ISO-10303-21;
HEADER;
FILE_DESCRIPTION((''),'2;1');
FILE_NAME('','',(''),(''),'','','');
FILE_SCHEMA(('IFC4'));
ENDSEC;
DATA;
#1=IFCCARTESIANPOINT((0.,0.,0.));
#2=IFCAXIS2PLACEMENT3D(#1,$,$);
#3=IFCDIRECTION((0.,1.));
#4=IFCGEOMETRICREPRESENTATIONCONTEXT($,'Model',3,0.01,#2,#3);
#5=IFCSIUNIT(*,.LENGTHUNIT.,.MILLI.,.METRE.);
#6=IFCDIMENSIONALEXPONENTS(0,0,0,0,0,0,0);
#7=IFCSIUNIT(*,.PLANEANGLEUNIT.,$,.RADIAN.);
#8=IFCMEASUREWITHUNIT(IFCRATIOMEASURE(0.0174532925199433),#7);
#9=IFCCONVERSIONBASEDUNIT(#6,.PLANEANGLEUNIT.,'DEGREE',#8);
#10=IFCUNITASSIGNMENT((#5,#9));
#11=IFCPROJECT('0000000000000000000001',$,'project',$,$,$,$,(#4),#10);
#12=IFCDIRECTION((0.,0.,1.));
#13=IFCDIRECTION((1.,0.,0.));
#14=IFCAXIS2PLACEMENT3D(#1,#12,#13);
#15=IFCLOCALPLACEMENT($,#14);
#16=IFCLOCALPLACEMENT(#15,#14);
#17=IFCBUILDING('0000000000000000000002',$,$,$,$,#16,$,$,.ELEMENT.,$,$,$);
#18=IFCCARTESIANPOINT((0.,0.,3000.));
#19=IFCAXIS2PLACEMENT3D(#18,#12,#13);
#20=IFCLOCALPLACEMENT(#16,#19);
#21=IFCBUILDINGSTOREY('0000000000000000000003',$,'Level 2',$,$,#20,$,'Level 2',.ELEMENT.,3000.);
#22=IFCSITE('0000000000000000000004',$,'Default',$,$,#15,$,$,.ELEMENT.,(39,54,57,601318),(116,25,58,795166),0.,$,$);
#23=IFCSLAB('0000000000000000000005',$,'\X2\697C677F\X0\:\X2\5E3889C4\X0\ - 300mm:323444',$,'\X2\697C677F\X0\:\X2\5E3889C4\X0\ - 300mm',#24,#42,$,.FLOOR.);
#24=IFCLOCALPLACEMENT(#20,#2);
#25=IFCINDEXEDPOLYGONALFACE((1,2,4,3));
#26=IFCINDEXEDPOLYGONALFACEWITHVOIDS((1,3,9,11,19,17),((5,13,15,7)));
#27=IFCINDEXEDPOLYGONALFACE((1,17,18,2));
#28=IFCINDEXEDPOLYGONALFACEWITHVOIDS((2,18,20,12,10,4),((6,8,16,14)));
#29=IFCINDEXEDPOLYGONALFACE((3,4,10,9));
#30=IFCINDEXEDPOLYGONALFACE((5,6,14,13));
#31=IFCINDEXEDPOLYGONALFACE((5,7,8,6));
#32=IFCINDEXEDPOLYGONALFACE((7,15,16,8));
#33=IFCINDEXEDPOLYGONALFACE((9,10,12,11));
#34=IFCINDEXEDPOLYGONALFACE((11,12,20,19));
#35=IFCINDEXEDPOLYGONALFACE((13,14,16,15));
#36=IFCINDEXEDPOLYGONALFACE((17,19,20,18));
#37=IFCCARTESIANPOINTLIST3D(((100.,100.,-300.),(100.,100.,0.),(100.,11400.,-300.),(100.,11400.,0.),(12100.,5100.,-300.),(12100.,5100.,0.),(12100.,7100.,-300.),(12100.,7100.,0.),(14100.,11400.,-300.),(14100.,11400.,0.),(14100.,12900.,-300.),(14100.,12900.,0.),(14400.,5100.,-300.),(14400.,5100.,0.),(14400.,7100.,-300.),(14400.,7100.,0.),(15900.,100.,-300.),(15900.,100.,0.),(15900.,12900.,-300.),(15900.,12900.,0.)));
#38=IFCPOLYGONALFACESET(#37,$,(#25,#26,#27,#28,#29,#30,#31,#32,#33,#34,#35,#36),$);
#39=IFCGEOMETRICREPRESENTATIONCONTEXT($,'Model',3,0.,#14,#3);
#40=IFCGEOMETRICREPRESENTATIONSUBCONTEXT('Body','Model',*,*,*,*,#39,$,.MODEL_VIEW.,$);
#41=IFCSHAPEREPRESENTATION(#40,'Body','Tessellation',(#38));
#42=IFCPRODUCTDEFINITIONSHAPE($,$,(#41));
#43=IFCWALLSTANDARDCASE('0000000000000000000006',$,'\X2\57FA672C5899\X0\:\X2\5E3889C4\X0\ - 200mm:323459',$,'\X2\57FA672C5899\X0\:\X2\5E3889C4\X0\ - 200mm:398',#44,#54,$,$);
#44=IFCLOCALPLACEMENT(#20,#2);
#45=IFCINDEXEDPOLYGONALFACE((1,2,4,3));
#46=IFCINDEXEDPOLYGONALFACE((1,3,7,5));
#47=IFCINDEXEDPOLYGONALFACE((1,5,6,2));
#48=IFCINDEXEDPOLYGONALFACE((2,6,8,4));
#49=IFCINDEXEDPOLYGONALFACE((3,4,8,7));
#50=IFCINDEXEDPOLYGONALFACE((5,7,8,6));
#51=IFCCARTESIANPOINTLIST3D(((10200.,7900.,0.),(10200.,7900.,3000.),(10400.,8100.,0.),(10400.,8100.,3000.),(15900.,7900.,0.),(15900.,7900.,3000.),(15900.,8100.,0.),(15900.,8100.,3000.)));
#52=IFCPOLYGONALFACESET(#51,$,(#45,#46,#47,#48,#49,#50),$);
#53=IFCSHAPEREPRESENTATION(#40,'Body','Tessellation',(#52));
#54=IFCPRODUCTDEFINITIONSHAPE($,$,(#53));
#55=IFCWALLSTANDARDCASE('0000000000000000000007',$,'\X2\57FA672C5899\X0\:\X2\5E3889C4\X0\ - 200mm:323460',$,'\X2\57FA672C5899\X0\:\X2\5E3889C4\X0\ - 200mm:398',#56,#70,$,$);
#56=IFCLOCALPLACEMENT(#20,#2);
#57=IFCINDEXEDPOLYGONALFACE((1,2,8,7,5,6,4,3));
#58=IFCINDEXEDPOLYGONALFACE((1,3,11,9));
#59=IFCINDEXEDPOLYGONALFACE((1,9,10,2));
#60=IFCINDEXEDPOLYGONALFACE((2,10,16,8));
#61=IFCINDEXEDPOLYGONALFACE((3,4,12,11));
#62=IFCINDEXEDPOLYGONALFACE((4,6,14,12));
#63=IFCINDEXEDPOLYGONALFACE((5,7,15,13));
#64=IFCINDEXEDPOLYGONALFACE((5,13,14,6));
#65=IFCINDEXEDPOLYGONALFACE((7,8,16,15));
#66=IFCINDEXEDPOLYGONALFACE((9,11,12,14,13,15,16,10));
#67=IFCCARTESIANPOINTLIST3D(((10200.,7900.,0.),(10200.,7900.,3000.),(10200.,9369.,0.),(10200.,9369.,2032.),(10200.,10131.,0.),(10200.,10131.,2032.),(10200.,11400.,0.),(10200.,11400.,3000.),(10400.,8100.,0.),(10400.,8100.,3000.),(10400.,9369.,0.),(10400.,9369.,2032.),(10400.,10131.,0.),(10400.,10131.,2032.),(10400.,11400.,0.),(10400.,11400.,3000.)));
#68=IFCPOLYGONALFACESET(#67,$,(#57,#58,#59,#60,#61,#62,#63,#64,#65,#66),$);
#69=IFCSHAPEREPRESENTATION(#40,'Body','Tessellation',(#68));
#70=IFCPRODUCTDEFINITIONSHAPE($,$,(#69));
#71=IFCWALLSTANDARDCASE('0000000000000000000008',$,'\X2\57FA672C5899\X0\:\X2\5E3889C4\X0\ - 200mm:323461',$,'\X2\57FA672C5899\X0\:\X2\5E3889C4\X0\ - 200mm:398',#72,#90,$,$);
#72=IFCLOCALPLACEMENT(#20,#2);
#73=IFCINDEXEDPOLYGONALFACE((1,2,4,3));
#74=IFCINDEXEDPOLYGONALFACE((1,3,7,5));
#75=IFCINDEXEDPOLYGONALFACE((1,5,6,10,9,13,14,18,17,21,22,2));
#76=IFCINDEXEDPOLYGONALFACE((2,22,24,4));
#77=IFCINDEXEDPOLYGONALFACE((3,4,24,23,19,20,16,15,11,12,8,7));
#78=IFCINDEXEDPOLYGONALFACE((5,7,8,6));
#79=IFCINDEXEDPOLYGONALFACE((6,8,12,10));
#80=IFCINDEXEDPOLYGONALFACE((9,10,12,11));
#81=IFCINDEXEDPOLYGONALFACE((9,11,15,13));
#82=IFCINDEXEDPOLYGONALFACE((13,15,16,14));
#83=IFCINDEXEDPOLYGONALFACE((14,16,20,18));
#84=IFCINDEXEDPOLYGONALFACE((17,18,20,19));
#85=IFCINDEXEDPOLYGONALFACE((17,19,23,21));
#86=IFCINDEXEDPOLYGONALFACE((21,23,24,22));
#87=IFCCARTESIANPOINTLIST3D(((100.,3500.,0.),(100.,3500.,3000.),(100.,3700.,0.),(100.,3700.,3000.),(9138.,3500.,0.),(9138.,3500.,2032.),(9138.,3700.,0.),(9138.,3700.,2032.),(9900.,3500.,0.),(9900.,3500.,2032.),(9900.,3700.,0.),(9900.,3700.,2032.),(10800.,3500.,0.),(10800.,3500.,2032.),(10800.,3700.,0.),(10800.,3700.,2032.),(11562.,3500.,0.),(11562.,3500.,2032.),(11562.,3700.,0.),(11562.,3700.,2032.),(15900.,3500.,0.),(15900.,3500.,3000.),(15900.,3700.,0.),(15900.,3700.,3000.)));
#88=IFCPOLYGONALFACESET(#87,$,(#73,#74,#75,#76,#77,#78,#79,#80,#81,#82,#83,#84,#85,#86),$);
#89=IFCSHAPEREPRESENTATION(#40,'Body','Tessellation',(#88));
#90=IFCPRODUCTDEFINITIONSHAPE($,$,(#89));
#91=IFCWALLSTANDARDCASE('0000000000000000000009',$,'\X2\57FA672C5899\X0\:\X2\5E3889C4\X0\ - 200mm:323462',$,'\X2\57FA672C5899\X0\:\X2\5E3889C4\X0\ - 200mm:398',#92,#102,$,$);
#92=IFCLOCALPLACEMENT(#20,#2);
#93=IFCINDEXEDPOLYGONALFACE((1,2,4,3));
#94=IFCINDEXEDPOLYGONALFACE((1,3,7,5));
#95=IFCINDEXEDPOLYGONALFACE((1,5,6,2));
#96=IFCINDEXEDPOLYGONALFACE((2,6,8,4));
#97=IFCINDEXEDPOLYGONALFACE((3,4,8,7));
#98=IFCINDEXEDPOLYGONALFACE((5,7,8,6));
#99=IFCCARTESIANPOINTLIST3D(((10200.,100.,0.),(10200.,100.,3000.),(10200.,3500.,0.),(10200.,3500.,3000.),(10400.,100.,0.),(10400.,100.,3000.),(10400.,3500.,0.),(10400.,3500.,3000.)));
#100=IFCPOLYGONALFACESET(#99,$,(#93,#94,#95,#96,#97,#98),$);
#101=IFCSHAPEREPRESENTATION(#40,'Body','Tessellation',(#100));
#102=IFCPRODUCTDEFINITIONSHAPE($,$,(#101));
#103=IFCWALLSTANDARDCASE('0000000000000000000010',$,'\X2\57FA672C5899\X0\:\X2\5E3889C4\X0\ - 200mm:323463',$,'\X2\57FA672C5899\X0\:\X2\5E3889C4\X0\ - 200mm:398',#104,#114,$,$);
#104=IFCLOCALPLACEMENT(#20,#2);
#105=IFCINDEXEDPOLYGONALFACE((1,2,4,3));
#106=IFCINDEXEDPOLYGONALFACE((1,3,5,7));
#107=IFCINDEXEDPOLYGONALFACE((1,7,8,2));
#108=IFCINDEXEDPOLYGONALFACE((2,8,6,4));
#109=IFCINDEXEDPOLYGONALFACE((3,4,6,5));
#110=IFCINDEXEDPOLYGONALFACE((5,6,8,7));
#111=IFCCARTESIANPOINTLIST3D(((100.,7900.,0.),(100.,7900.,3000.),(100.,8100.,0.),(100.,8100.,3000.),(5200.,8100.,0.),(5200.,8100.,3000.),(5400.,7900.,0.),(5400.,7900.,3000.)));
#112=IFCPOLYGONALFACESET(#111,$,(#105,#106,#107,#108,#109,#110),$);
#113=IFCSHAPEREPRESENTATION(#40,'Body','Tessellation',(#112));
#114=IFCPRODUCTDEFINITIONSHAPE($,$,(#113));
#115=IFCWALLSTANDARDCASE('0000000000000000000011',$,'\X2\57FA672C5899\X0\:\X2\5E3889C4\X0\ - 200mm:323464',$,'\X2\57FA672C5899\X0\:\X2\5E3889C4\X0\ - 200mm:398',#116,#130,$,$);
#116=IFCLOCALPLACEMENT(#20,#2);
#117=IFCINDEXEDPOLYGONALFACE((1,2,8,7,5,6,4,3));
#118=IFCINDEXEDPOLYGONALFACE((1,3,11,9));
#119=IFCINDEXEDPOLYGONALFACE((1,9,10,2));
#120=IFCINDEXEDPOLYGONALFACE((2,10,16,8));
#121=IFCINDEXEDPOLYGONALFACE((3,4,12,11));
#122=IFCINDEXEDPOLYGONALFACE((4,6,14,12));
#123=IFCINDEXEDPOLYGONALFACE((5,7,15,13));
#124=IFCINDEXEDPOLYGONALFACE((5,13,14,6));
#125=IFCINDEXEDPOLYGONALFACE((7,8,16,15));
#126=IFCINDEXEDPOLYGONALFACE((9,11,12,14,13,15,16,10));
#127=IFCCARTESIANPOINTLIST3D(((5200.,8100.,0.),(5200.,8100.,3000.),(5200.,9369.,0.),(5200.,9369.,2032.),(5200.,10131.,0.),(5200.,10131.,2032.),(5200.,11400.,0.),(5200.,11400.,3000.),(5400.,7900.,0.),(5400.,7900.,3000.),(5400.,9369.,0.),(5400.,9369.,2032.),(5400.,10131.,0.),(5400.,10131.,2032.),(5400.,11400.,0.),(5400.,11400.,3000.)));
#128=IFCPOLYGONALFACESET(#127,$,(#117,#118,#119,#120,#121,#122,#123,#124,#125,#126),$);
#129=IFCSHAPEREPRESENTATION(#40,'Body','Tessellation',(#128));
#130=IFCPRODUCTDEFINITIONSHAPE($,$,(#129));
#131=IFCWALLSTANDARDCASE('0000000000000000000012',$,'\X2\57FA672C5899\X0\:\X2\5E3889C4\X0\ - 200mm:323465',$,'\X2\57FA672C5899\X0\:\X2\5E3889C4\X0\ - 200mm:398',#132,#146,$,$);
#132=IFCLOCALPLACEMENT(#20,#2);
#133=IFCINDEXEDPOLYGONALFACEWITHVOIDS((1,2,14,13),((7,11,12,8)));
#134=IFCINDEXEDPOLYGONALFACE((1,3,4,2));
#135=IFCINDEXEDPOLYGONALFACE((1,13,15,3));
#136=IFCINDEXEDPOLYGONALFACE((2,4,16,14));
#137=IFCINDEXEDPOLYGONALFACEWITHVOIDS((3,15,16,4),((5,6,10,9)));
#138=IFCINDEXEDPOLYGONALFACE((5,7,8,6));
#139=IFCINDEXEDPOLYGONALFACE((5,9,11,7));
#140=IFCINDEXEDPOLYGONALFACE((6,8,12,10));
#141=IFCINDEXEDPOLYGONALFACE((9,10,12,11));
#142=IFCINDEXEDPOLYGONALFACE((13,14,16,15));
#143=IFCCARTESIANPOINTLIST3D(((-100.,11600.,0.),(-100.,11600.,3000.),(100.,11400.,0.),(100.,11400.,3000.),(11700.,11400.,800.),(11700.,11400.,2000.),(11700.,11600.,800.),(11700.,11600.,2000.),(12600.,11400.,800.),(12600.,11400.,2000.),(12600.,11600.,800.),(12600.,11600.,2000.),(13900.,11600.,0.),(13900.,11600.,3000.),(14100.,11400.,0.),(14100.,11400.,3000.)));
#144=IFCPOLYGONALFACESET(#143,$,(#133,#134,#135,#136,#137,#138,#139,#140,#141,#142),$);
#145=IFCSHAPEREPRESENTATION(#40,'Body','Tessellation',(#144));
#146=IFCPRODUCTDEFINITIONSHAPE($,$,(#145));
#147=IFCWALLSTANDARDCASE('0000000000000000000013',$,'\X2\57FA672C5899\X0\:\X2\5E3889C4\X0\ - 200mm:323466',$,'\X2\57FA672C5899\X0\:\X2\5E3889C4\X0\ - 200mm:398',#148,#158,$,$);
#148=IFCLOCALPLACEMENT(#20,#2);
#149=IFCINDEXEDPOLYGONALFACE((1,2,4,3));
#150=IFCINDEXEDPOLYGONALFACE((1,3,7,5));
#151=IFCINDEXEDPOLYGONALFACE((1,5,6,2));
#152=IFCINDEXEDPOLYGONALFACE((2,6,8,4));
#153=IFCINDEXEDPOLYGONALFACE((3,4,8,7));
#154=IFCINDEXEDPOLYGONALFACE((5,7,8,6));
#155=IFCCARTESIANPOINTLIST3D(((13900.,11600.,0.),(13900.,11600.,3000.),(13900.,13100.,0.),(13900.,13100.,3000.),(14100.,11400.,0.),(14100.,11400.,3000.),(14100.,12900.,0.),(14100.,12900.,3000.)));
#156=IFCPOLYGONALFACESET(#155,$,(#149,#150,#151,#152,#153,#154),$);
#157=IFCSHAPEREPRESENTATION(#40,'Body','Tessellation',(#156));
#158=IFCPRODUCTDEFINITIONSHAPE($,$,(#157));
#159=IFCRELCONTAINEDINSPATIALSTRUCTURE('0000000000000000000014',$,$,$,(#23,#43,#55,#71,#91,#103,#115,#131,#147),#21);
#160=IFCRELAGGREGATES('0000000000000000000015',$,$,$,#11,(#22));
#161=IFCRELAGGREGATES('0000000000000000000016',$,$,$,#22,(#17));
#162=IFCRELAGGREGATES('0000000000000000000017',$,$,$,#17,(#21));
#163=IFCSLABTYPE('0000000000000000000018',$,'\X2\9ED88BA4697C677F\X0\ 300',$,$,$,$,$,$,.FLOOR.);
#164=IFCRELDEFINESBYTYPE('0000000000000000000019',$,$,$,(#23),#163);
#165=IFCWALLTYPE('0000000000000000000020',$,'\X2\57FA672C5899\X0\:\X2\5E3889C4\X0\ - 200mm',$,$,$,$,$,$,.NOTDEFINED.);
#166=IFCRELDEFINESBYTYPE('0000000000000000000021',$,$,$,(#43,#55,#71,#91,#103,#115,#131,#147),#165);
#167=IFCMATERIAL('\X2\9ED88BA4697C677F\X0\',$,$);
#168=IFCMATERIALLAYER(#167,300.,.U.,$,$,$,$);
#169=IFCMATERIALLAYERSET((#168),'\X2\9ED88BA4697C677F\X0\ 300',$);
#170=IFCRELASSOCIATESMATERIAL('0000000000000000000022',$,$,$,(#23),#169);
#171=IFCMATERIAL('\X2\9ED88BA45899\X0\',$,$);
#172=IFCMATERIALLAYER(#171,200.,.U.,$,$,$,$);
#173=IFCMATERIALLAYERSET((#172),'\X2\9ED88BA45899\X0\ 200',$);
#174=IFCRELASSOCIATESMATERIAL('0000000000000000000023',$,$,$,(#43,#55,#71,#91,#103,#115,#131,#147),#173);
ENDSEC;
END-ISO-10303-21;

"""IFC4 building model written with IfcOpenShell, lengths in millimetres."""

from ifc_helpers import new_model, entity, si_unit, converted_unit, direction, frame, origin, origin_with_axes, place, context, subcontext, project, spatial, polyline, outline, extrude, material, layer, layer_set, layer_usage, type_object, element, save


model = new_model("IFC4")

# Units and contexts
model_context_1 = context("Model", 3, precision=0.01, world=origin(), true_north=direction((0.0, 1.0)))
model_context_2 = context("Model", 3, precision=0.0, world=origin_with_axes(), true_north=direction((0.0, 1.0)))
body_context = subcontext(model_context_2, "Body", "Model", "MODEL_VIEW")
ifc_project = project(units=[si_unit("LENGTHUNIT", "METRE", prefix="MILLI"), converted_unit("PLANEANGLEUNIT", "DEGREE", entity("IfcRatioMeasure", 0.0174532925199433), si_unit("PLANEANGLEUNIT", "RADIAN"), dimensions=[0, 0, 0, 0, 0, 0, 0])], contexts=[model_context_1])

# Site, building, storey
site_placement = place(None, origin_with_axes())
site = spatial("IfcSite", under=ifc_project, at=site_placement, Name="Default", CompositionType="ELEMENT", RefLatitude=(39, 54, 57, 601318), RefLongitude=(116, 25, 58, 795166), RefElevation=0.0)
building_placement = place(site_placement, origin_with_axes())
building = spatial("IfcBuilding", under=site, at=building_placement, CompositionType="ELEMENT")
storey_placement = place(building_placement, frame((0.0, 0.0, 3000.0), z_axis=(0.0, 0.0, 1.0), x_axis=(1.0, 0.0, 0.0)))
storey = spatial("IfcBuildingStorey", under=building, at=storey_placement, Name="Level 2", LongName="Level 2", CompositionType="ELEMENT", Elevation=3000.0)

# Slab, opening
ifc_material_1 = material(Name="默认楼板")
ifc_layer_1 = layer(ifc_material_1, 300.0, ventilated="UNKNOWN")
ifc_layer_set_1 = layer_set([ifc_layer_1], Name="默认楼板 300")
ifc_layer_usage_1 = layer_usage(ifc_layer_set_1, "AXIS3", "NEGATIVE", 300.0)
slab_type = type_object("IfcSlabType", Name="默认楼板 300", PredefinedType="FLOOR")
slab_placement = place(storey_placement, frame((15900.0, 12900.0, -300.0), z_axis=(0.0, 0.0, 1.0), x_axis=(1.0, 0.0, 0.0)))
slab = element("IfcSlab", 1, at=slab_placement, inside=storey, type_object=slab_type, material=ifc_layer_usage_1, Name="楼板:常规 - 300mm:323444", ObjectType="楼板:常规 - 300mm", PredefinedType="FLOOR", context=body_context, shape_type="SweptSolid", body=[
    extrude(outline(polyline([(0.0, 0.0), (-1800.0, 0.0), (-1800.0, -1500.0), (-15800.0, -1500.0), (-15800.0, -12800.0), (0.0, -12800.0), (0.0, 0.0)])), origin_with_axes(), (0.0, 0.0, 1.0), 300.0),
])
opening_1_placement = place(slab_placement, origin_with_axes())
element("IfcOpeningElement", 2, at=opening_1_placement, cuts=slab, context=body_context, shape_type="SweptSolid", body=[
    extrude(outline(polyline([(-3800.0, -7800.0), (-1500.0, -7800.0), (-1500.0, -5800.0), (-3800.0, -5800.0), (-3800.0, -7800.0)])), origin_with_axes(), (0.0, 0.0, 1.0), 300.0),
])

# Wall
ifc_material_2 = material(Name="默认墙")
ifc_layer_2 = layer(ifc_material_2, 200.0, ventilated="UNKNOWN")
ifc_layer_set_2 = layer_set([ifc_layer_2], Name="默认墙 200")
ifc_layer_usage_2 = layer_usage(ifc_layer_set_2, "AXIS2", "POSITIVE", -100.0)
wall_type = type_object("IfcWallType", Name="基本墙:常规 - 200mm", PredefinedType="NOTDEFINED")
wall_1_placement = place(storey_placement, frame((10300.0, 8000.0, 0.0), z_axis=(0.0, 0.0, 1.0), x_axis=(1.0, 0.0, 0.0)))
element("IfcWallStandardCase", 3, at=wall_1_placement, inside=storey, type_object=wall_type, material=ifc_layer_usage_2, Name="基本墙:常规 - 200mm:323459", ObjectType="基本墙:常规 - 200mm:398", context=body_context, shape_type="SweptSolid", body=[
    extrude(outline(polyline([(-100.0, -100.0), (5600.0, -100.0), (5600.0, 100.0), (100.0, 100.0), (-100.0, -100.0)])), origin_with_axes(), (0.0, 0.0, 1.0), 3000.0),
])

# Wall, opening
ifc_layer_usage_3 = layer_usage(ifc_layer_set_2, "AXIS2", "POSITIVE", -100.0)
wall_2_placement = place(storey_placement, frame((10300.0, 11500.0, 0.0), z_axis=(0.0, 0.0, 1.0), x_axis=(0.0, -1.0, 0.0)))
wall_2 = element("IfcWallStandardCase", 4, at=wall_2_placement, inside=storey, type_object=wall_type, material=ifc_layer_usage_3, Name="基本墙:常规 - 200mm:323460", ObjectType="基本墙:常规 - 200mm:398", context=body_context, shape_type="SweptSolid", body=[
    extrude(outline(polyline([(100.0, -100.0), (3600.0, -100.0), (3400.0, 100.0), (100.0, 100.0), (100.0, -100.0)])), origin_with_axes(), (0.0, 0.0, 1.0), 3000.0),
])
opening_2_placement = place(wall_2_placement, frame((1750.0, 0.0, 0.0), z_axis=(0.0, 0.0, 1.0), x_axis=(1.0, 0.0, 0.0)))
element("IfcOpeningElement", 5, at=opening_2_placement, cuts=wall_2, context=body_context, shape_type="SweptSolid", body=[
    extrude(outline(polyline([(-381.0, -2032.0), (381.0, -2032.0), (381.0, 0.0), (-381.0, 0.0), (-381.0, -2032.0)])), frame((0.0, 100.0, 0.0), z_axis=(0.0, -1.0, 0.0), x_axis=(-1.0, 0.0, 0.0)), (0.0, 0.0, 1.0), 200.0),
])

# Wall, openings
ifc_layer_usage_4 = layer_usage(ifc_layer_set_2, "AXIS2", "POSITIVE", -100.0)
wall_3_placement = place(storey_placement, frame((16000.0, 3600.0, 0.0), z_axis=(0.0, 0.0, 1.0), x_axis=(-1.0, 0.0, 0.0)))
wall_3 = element("IfcWallStandardCase", 6, at=wall_3_placement, inside=storey, type_object=wall_type, material=ifc_layer_usage_4, Name="基本墙:常规 - 200mm:323461", ObjectType="基本墙:常规 - 200mm:398", context=body_context, shape_type="SweptSolid", body=[
    extrude(outline(polyline([(100.0, -100.0), (15900.0, -100.0), (15900.0, 100.0), (100.0, 100.0), (100.0, -100.0)])), origin_with_axes(), (0.0, 0.0, 1.0), 3000.0),
])
opening_3_placement = place(wall_3_placement, frame((6481.0, 0.0, 0.0), z_axis=(0.0, 0.0, 1.0), x_axis=(1.0, 0.0, 0.0)))
element("IfcOpeningElement", 7, at=opening_3_placement, cuts=wall_3, context=body_context, shape_type="SweptSolid", body=[
    extrude(outline(polyline([(-381.0, 0.0), (-381.0, -2032.0), (381.0, -2032.0), (381.0, 0.0), (-381.0, 0.0)])), frame((0.0, 100.0, 0.0), z_axis=(0.0, 1.0, 0.0), x_axis=(1.0, 0.0, 0.0)), (0.0, 0.0, -1.0), 200.0),
])
opening_4_placement = place(wall_3_placement, frame((4819.0, 0.0, 0.0), z_axis=(0.0, 0.0, 1.0), x_axis=(1.0, 0.0, 0.0)))
element("IfcOpeningElement", 8, at=opening_4_placement, cuts=wall_3, context=body_context, shape_type="SweptSolid", body=[
    extrude(outline(polyline([(-381.0, -2032.0), (381.0, -2032.0), (381.0, 0.0), (-381.0, 0.0), (-381.0, -2032.0)])), frame((0.0, 100.0, 0.0), z_axis=(0.0, -1.0, 0.0), x_axis=(-1.0, 0.0, 0.0)), (0.0, 0.0, 1.0), 200.0),
])

# Walls
ifc_layer_usage_5 = layer_usage(ifc_layer_set_2, "AXIS2", "POSITIVE", -100.0)
wall_4_placement = place(storey_placement, frame((10300.0, 3600.0, 0.0), z_axis=(0.0, 0.0, 1.0), x_axis=(0.0, -1.0, 0.0)))
element("IfcWallStandardCase", 9, at=wall_4_placement, inside=storey, type_object=wall_type, material=ifc_layer_usage_5, Name="基本墙:常规 - 200mm:323462", ObjectType="基本墙:常规 - 200mm:398", context=body_context, shape_type="SweptSolid", body=[
    extrude(outline(polyline([(100.0, -100.0), (3500.0, -100.0), (3500.0, 100.0), (100.0, 100.0), (100.0, -100.0)])), origin_with_axes(), (0.0, 0.0, 1.0), 3000.0),
])
ifc_layer_usage_6 = layer_usage(ifc_layer_set_2, "AXIS2", "POSITIVE", -100.0)
wall_5_placement = place(storey_placement, frame((0.0, 8000.0, 0.0), z_axis=(0.0, 0.0, 1.0), x_axis=(1.0, 0.0, 0.0)))
element("IfcWallStandardCase", 10, at=wall_5_placement, inside=storey, type_object=wall_type, material=ifc_layer_usage_6, Name="基本墙:常规 - 200mm:323463", ObjectType="基本墙:常规 - 200mm:398", context=body_context, shape_type="SweptSolid", body=[
    extrude(outline(polyline([(100.0, -100.0), (5400.0, -100.0), (5200.0, 100.0), (100.0, 100.0), (100.0, -100.0)])), origin_with_axes(), (0.0, 0.0, 1.0), 3000.0),
])

# Walls, openings
ifc_layer_usage_7 = layer_usage(ifc_layer_set_2, "AXIS2", "POSITIVE", -100.0)
wall_6_placement = place(storey_placement, frame((5300.0, 8000.0, 0.0), z_axis=(0.0, 0.0, 1.0), x_axis=(0.0, 1.0, 0.0)))
wall_6 = element("IfcWallStandardCase", 11, at=wall_6_placement, inside=storey, type_object=wall_type, material=ifc_layer_usage_7, Name="基本墙:常规 - 200mm:323464", ObjectType="基本墙:常规 - 200mm:398", context=body_context, shape_type="SweptSolid", body=[
    extrude(outline(polyline([(-100.0, -100.0), (3400.0, -100.0), (3400.0, 100.0), (100.0, 100.0), (-100.0, -100.0)])), origin_with_axes(), (0.0, 0.0, 1.0), 3000.0),
])
opening_5_placement = place(wall_6_placement, frame((1750.0, 0.0, 0.0), z_axis=(0.0, 0.0, 1.0), x_axis=(1.0, 0.0, 0.0)))
element("IfcOpeningElement", 12, at=opening_5_placement, cuts=wall_6, context=body_context, shape_type="SweptSolid", body=[
    extrude(outline(polyline([(-381.0, -2032.0), (381.0, -2032.0), (381.0, 0.0), (-381.0, 0.0), (-381.0, -2032.0)])), frame((0.0, 100.0, 0.0), z_axis=(0.0, -1.0, 0.0), x_axis=(-1.0, 0.0, 0.0)), (0.0, 0.0, 1.0), 200.0),
])
ifc_layer_usage_8 = layer_usage(ifc_layer_set_2, "AXIS2", "POSITIVE", -100.0)
wall_7_placement = place(storey_placement, frame((0.0, 11500.0, 0.0), z_axis=(0.0, 0.0, 1.0), x_axis=(1.0, 0.0, 0.0)))
wall_7 = element("IfcWallStandardCase", 13, at=wall_7_placement, inside=storey, type_object=wall_type, material=ifc_layer_usage_8, Name="基本墙:常规 - 200mm:323465", ObjectType="基本墙:常规 - 200mm:398", context=body_context, shape_type="SweptSolid", body=[
    extrude(outline(polyline([(100.0, -100.0), (14100.0, -100.0), (13900.0, 100.0), (-100.0, 100.0), (100.0, -100.0)])), origin_with_axes(), (0.0, 0.0, 1.0), 3000.0),
])
opening_6_placement = place(wall_7_placement, frame((12150.0, 0.0, 800.0), z_axis=(0.0, 0.0, 1.0), x_axis=(1.0, 0.0, 0.0)))
element("IfcOpeningElement", 14, at=opening_6_placement, cuts=wall_7, context=body_context, shape_type="SweptSolid", body=[
    extrude(outline(polyline([(450.0, -1200.0), (450.0, 0.0), (-450.0, 0.0), (-450.0, -1200.0), (450.0, -1200.0)])), frame((0.0, 100.0, 0.0), z_axis=(0.0, -1.0, 0.0), x_axis=(-1.0, 0.0, 0.0)), (0.0, 0.0, 1.0), 200.0),
])

# Wall
ifc_layer_usage_9 = layer_usage(ifc_layer_set_2, "AXIS2", "POSITIVE", -100.0)
wall_8_placement = place(storey_placement, frame((14000.0, 11500.0, 0.0), z_axis=(0.0, 0.0, 1.0), x_axis=(0.0, 1.0, 0.0)))
element("IfcWallStandardCase", 15, at=wall_8_placement, inside=storey, type_object=wall_type, material=ifc_layer_usage_9, Name="基本墙:常规 - 200mm:323466", ObjectType="基本墙:常规 - 200mm:398", context=body_context, shape_type="SweptSolid", body=[
    extrude(outline(polyline([(-100.0, -100.0), (1400.0, -100.0), (1600.0, 100.0), (100.0, 100.0), (-100.0, -100.0)])), origin_with_axes(), (0.0, 0.0, 1.0), 3000.0),
])

save(model, "model.ifc")
